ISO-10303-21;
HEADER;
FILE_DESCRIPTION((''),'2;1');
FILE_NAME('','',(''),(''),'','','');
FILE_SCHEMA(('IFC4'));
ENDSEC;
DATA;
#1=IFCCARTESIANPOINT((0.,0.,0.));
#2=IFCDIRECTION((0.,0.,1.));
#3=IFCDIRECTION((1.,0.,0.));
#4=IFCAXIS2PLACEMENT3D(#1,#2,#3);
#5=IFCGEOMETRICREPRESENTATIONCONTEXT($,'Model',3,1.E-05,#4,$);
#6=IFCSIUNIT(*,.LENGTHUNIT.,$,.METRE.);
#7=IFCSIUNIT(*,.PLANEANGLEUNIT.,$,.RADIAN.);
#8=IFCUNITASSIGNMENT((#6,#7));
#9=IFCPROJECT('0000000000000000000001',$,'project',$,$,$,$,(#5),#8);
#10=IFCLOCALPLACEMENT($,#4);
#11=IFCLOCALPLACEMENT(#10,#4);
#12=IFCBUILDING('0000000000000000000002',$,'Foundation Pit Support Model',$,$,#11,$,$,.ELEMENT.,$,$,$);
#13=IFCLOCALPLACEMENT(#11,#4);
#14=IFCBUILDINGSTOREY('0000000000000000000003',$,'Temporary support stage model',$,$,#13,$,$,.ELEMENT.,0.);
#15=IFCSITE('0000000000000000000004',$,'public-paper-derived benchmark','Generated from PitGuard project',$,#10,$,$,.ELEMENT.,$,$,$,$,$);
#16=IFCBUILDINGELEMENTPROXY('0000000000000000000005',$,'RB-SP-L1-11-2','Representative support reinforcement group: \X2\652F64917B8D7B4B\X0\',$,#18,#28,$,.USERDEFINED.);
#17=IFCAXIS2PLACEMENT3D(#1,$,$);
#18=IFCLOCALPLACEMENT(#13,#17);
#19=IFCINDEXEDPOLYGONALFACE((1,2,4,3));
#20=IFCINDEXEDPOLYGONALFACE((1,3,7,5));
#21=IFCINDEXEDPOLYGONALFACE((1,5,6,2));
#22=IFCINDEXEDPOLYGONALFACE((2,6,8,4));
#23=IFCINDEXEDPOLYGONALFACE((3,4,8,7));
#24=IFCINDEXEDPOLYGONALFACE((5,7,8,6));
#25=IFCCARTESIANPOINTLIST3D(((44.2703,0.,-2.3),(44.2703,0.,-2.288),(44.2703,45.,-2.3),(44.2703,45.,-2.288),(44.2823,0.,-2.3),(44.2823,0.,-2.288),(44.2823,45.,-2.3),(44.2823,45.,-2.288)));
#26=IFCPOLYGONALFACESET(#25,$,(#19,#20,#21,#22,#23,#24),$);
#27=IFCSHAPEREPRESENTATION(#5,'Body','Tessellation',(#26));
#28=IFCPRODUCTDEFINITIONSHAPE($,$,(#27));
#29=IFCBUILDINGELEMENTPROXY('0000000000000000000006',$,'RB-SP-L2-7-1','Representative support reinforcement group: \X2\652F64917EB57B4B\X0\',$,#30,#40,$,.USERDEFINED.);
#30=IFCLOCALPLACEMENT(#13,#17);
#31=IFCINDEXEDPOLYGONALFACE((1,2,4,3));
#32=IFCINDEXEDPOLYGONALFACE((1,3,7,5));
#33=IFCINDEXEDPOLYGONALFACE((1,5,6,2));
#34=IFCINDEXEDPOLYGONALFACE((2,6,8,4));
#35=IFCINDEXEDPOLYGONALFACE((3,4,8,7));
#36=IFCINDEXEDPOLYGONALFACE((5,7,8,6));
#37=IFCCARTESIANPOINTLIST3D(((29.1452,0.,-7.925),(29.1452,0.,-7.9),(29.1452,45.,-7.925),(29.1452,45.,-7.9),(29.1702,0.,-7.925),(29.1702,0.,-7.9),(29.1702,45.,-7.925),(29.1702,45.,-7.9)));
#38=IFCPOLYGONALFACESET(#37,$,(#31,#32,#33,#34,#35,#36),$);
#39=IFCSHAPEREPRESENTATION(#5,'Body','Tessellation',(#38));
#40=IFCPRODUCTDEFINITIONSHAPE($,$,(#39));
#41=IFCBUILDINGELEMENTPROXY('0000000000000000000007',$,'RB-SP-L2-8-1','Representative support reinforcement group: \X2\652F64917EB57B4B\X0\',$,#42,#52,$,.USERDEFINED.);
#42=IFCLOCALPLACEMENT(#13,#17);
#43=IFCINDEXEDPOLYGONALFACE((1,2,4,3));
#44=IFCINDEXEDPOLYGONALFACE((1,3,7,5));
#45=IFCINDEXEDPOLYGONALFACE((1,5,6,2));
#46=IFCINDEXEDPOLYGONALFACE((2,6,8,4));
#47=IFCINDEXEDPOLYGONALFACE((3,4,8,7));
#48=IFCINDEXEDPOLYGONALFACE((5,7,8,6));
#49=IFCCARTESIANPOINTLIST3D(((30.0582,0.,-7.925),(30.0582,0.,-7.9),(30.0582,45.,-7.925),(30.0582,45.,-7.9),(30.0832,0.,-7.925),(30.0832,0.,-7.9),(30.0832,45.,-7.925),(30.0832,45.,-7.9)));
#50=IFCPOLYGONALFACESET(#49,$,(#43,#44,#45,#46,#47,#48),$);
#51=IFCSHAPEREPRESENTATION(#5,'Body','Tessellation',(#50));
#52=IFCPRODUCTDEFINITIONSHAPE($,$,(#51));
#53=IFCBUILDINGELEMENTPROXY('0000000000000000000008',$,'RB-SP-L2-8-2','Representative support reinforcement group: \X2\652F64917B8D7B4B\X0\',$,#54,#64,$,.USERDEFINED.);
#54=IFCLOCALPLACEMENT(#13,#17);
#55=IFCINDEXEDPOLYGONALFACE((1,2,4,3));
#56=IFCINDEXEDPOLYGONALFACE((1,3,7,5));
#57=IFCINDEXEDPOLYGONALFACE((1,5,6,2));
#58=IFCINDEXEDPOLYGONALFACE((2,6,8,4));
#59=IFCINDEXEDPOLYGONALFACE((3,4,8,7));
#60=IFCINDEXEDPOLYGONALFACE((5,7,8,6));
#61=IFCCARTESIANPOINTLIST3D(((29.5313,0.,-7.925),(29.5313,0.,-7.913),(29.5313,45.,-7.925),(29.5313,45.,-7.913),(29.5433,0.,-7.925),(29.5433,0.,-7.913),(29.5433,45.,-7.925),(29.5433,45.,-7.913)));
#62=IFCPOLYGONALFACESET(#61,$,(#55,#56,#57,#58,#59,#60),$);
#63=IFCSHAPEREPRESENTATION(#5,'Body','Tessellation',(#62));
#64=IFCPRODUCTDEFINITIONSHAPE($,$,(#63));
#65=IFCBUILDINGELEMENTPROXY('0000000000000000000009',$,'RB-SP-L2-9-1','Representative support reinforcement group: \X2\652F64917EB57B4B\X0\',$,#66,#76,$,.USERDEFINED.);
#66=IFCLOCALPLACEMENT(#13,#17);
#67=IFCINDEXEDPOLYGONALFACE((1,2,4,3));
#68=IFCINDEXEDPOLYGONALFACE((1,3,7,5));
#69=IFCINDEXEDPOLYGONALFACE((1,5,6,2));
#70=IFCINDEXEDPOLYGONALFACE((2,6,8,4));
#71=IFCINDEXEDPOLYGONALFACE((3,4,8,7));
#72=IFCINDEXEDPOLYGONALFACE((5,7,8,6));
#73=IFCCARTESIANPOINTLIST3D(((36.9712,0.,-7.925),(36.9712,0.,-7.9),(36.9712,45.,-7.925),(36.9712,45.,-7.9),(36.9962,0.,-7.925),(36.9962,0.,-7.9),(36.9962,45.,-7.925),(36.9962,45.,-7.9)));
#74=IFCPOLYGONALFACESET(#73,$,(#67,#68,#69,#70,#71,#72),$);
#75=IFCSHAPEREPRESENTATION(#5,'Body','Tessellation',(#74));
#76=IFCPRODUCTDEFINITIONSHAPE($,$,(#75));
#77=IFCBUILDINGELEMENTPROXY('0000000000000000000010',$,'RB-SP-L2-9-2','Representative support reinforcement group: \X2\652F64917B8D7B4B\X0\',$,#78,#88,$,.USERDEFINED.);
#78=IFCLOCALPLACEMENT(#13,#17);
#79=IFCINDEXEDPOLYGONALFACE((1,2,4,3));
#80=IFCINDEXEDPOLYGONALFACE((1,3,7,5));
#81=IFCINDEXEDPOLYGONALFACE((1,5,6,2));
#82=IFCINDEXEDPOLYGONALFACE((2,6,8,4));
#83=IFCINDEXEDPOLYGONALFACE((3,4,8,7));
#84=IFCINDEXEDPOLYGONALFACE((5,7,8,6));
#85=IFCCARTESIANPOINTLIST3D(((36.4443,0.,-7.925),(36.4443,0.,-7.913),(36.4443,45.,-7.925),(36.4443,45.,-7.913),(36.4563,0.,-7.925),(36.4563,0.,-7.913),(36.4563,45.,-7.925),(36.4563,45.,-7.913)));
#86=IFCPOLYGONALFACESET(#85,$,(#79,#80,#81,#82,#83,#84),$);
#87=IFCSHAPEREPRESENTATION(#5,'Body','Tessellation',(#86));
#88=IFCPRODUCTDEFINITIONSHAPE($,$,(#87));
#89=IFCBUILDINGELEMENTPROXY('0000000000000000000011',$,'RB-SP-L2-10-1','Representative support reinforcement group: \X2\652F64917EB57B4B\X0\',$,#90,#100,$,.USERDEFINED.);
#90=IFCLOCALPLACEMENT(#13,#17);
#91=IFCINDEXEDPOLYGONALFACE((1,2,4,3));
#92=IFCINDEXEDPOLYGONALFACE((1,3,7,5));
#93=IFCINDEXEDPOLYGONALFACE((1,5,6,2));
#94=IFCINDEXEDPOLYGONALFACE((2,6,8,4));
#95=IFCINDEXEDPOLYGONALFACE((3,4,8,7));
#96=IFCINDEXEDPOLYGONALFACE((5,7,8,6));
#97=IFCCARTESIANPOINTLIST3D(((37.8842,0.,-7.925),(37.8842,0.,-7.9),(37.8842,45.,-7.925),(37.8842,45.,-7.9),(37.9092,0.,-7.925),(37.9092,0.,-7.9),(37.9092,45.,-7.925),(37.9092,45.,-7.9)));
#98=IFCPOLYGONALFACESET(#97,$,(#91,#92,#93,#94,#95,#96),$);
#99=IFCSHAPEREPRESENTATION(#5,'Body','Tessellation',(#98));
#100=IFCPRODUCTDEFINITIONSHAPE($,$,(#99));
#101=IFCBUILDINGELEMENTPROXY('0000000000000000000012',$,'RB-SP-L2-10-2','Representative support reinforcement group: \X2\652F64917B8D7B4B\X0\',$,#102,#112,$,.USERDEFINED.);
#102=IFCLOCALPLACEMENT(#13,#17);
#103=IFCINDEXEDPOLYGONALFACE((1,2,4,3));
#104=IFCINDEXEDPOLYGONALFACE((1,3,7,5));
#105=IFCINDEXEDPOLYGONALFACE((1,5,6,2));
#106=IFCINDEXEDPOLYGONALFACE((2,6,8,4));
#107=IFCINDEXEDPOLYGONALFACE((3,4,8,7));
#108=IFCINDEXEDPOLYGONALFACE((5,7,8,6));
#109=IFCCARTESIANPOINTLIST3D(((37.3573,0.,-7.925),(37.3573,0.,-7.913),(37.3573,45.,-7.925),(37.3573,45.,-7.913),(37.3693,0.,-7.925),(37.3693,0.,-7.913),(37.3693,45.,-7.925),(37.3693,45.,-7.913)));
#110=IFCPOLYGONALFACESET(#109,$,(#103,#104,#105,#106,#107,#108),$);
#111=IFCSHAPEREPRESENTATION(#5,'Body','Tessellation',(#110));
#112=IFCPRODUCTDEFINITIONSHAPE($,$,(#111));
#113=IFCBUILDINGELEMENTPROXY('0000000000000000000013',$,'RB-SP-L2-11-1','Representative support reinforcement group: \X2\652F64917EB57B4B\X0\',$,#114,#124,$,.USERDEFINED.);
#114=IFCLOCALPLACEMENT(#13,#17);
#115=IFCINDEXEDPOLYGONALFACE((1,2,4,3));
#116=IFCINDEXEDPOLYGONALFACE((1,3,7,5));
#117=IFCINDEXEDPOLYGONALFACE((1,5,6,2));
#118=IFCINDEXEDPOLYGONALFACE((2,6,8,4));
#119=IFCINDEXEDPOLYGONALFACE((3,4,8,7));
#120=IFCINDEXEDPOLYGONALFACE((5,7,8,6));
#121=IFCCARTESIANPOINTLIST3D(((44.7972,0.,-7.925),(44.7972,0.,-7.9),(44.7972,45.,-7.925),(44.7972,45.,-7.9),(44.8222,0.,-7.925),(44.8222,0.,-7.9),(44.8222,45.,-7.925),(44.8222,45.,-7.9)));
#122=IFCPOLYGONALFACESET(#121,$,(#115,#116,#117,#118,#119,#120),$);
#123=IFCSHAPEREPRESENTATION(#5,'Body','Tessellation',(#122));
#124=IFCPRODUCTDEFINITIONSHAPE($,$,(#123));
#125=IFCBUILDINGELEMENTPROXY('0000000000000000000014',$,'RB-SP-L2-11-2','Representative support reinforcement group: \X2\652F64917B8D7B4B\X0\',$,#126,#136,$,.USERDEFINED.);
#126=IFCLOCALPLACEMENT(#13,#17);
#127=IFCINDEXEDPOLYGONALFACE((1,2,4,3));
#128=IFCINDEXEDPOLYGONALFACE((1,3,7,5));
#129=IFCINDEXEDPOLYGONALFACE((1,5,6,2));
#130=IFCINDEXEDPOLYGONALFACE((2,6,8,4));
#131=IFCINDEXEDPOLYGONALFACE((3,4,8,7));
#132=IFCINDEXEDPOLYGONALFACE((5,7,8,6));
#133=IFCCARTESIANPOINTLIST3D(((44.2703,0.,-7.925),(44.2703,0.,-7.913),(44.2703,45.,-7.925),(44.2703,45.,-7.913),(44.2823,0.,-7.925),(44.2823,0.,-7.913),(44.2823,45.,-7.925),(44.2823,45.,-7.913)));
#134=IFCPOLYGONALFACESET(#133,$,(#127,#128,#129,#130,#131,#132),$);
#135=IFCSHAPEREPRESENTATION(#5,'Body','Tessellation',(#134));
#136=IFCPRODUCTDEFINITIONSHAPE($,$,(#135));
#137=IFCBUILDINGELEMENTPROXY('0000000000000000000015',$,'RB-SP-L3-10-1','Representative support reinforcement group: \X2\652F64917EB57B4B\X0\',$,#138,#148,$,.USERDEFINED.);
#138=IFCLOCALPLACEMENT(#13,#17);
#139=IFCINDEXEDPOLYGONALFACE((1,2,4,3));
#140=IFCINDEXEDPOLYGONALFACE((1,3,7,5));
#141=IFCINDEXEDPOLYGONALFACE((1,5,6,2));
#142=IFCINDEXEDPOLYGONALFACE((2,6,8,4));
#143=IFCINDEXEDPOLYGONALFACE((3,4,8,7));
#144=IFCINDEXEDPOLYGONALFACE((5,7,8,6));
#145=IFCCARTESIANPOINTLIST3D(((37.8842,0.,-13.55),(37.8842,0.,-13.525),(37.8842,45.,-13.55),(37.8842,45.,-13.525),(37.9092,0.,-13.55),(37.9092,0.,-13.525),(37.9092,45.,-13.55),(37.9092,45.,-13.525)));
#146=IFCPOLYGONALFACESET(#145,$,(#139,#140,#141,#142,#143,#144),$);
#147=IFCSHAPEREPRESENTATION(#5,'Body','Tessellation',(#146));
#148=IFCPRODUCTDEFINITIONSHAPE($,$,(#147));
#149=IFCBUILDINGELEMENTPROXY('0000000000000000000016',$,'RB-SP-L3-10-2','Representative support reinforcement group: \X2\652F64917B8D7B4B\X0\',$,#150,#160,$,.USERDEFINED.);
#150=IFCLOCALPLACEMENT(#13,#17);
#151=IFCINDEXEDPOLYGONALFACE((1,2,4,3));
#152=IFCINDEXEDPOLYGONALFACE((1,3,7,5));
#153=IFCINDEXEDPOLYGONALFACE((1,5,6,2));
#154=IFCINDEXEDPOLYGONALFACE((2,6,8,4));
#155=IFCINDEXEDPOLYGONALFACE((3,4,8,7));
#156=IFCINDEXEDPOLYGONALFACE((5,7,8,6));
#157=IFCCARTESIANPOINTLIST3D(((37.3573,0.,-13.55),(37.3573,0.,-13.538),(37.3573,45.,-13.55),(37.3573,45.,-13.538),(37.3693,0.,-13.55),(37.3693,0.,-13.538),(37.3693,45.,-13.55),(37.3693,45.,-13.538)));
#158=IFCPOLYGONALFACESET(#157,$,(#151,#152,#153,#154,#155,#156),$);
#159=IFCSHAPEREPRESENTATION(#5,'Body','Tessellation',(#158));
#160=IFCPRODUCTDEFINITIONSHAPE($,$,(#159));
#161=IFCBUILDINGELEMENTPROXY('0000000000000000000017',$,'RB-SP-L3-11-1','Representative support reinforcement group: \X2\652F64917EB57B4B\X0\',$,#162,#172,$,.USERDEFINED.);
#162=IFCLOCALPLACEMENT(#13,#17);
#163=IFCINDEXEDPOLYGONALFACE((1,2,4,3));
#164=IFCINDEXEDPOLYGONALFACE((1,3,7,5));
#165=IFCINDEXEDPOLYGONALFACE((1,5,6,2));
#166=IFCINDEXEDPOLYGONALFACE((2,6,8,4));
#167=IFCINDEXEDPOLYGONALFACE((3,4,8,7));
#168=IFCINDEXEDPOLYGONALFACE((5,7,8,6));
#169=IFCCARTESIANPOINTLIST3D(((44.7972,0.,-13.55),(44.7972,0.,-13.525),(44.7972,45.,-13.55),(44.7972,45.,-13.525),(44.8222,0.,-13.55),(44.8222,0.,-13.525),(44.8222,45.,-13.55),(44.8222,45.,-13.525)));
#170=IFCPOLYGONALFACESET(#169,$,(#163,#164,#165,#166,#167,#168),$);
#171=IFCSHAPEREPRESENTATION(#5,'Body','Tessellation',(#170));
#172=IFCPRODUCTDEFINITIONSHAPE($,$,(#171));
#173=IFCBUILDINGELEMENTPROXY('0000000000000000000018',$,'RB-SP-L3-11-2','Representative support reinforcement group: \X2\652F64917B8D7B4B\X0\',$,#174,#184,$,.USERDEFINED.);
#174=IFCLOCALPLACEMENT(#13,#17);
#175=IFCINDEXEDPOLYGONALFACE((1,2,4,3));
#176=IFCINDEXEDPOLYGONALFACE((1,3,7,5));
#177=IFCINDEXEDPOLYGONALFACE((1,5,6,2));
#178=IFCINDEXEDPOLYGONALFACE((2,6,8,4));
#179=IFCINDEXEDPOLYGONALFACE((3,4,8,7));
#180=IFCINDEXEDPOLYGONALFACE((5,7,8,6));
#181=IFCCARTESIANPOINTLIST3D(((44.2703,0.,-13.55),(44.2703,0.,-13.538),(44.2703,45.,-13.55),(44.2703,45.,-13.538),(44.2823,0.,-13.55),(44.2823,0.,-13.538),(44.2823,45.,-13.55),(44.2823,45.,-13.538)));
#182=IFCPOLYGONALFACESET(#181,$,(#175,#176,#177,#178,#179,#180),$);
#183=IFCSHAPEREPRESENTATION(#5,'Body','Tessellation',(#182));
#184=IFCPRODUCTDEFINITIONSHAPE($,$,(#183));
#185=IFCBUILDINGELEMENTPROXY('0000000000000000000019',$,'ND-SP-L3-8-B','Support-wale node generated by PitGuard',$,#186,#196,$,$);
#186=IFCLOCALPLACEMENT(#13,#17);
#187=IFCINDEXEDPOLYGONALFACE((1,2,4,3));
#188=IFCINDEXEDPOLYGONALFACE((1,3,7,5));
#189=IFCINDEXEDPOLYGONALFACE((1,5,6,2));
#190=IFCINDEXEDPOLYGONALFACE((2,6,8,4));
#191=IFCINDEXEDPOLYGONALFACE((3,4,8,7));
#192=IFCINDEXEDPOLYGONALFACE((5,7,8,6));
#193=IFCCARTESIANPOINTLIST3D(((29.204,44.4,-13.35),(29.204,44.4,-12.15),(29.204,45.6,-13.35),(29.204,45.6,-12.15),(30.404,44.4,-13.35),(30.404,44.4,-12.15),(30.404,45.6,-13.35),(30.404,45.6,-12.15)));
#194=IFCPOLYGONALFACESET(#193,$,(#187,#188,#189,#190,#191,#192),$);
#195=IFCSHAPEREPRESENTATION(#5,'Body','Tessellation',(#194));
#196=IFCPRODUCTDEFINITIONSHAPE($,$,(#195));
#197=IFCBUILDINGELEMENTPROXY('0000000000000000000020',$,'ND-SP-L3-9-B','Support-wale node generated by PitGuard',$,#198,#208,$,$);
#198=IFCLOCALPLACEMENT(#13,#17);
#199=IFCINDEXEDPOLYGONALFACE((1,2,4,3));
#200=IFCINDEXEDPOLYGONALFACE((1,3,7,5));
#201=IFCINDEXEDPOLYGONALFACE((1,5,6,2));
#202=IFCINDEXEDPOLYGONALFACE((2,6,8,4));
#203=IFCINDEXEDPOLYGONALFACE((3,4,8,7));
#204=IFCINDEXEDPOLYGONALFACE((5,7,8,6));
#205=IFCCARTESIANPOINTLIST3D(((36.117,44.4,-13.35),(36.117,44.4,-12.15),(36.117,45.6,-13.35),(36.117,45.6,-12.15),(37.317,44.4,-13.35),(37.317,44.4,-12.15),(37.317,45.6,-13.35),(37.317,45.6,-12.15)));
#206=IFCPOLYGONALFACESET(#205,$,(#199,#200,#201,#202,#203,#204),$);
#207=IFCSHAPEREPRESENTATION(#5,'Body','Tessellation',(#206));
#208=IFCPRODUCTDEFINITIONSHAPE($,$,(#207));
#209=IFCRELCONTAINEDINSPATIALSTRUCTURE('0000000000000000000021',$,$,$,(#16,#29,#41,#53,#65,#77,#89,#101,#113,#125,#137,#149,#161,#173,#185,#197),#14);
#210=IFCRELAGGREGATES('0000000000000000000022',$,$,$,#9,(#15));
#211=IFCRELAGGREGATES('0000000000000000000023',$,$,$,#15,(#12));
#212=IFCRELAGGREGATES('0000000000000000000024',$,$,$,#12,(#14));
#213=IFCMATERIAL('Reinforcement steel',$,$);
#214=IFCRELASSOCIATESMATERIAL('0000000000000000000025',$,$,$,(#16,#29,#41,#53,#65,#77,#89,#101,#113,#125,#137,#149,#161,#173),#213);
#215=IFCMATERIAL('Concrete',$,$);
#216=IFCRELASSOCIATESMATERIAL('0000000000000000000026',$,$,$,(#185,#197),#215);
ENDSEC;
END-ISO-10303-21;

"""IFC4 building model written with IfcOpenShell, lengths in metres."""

from ifc_helpers import new_model, si_unit, frame, origin_with_axes, origin_2d, place, context, project, spatial, rectangle, extrude, material, element, save


model = new_model("IFC4")

# Units and contexts
model_context = context("Model", 3, precision=1e-05, world=origin_with_axes())
ifc_project = project(units=[si_unit("LENGTHUNIT", "METRE"), si_unit("PLANEANGLEUNIT", "RADIAN")], contexts=[model_context])

# Site, building, storey
site_placement = place(None, origin_with_axes())
site = spatial("IfcSite", under=ifc_project, at=site_placement, Name="public-paper-derived benchmark", Description="Generated from PitGuard project", CompositionType="ELEMENT")
building_placement = place(site_placement, origin_with_axes())
building = spatial("IfcBuilding", under=site, at=building_placement, Name="Foundation Pit Support Model", CompositionType="ELEMENT")
storey_placement = place(building_placement, origin_with_axes())
storey = spatial("IfcBuildingStorey", under=building, at=storey_placement, Name="Temporary support stage model", CompositionType="ELEMENT", Elevation=0.0)

# Shared definitions
ifc_material_1 = material(Name="Concrete")

# Building element proxies
ifc_material_2 = material(Name="Reinforcement steel")
proxy_1_placement = place(storey_placement, frame((44.2763, 22.5, -2.3), z_axis=(0.0, 0.0, 1.0), x_axis=(0.0, 1.0, 0.0)))
element("IfcBuildingElementProxy", 1, at=proxy_1_placement, inside=storey, material=ifc_material_2, Name="RB-SP-L1-11-2", Description="Representative support reinforcement group: 支撑箍筋", PredefinedType="USERDEFINED", context=model_context, shape_type="SweptSolid", body=[
    extrude(rectangle(XDim=45.0, YDim=0.012, at=origin_2d()), origin_with_axes(), (0.0, 0.0, 1.0), 0.012),
])
for number, where, z_axis, x_axis, name in (
    (2, (29.1577, 22.5, -7.925), (0.0, 0.0, 1.0), (0.0, 1.0, 0.0), "RB-SP-L2-7-1"),
    (3, (30.0707, 22.5, -7.925), (0.0, 0.0, 1.0), (0.0, 1.0, 0.0), "RB-SP-L2-8-1"),
):
    element("IfcBuildingElementProxy", number, at=place(storey_placement, frame(where, z_axis=z_axis, x_axis=x_axis)), inside=storey, material=ifc_material_2, Name=name, Description="Representative support reinforcement group: 支撑纵筋", PredefinedType="USERDEFINED", context=model_context, shape_type="SweptSolid", body=[
        extrude(rectangle(XDim=45.0, YDim=0.025, at=origin_2d()), origin_with_axes(), (0.0, 0.0, 1.0), 0.025),
    ])
proxy_2_placement = place(storey_placement, frame((29.5373, 22.5, -7.925), z_axis=(0.0, 0.0, 1.0), x_axis=(0.0, 1.0, 0.0)))
element("IfcBuildingElementProxy", 4, at=proxy_2_placement, inside=storey, material=ifc_material_2, Name="RB-SP-L2-8-2", Description="Representative support reinforcement group: 支撑箍筋", PredefinedType="USERDEFINED", context=model_context, shape_type="SweptSolid", body=[
    extrude(rectangle(XDim=45.0, YDim=0.012, at=origin_2d()), origin_with_axes(), (0.0, 0.0, 1.0), 0.012),
])
proxy_3_placement = place(storey_placement, frame((36.9837, 22.5, -7.925), z_axis=(0.0, 0.0, 1.0), x_axis=(0.0, 1.0, 0.0)))
element("IfcBuildingElementProxy", 5, at=proxy_3_placement, inside=storey, material=ifc_material_2, Name="RB-SP-L2-9-1", Description="Representative support reinforcement group: 支撑纵筋", PredefinedType="USERDEFINED", context=model_context, shape_type="SweptSolid", body=[
    extrude(rectangle(XDim=45.0, YDim=0.025, at=origin_2d()), origin_with_axes(), (0.0, 0.0, 1.0), 0.025),
])
proxy_4_placement = place(storey_placement, frame((36.4503, 22.5, -7.925), z_axis=(0.0, 0.0, 1.0), x_axis=(0.0, 1.0, 0.0)))
element("IfcBuildingElementProxy", 6, at=proxy_4_placement, inside=storey, material=ifc_material_2, Name="RB-SP-L2-9-2", Description="Representative support reinforcement group: 支撑箍筋", PredefinedType="USERDEFINED", context=model_context, shape_type="SweptSolid", body=[
    extrude(rectangle(XDim=45.0, YDim=0.012, at=origin_2d()), origin_with_axes(), (0.0, 0.0, 1.0), 0.012),
])
proxy_5_placement = place(storey_placement, frame((37.8967, 22.5, -7.925), z_axis=(0.0, 0.0, 1.0), x_axis=(0.0, 1.0, 0.0)))
element("IfcBuildingElementProxy", 7, at=proxy_5_placement, inside=storey, material=ifc_material_2, Name="RB-SP-L2-10-1", Description="Representative support reinforcement group: 支撑纵筋", PredefinedType="USERDEFINED", context=model_context, shape_type="SweptSolid", body=[
    extrude(rectangle(XDim=45.0, YDim=0.025, at=origin_2d()), origin_with_axes(), (0.0, 0.0, 1.0), 0.025),
])
proxy_6_placement = place(storey_placement, frame((37.3633, 22.5, -7.925), z_axis=(0.0, 0.0, 1.0), x_axis=(0.0, 1.0, 0.0)))
element("IfcBuildingElementProxy", 8, at=proxy_6_placement, inside=storey, material=ifc_material_2, Name="RB-SP-L2-10-2", Description="Representative support reinforcement group: 支撑箍筋", PredefinedType="USERDEFINED", context=model_context, shape_type="SweptSolid", body=[
    extrude(rectangle(XDim=45.0, YDim=0.012, at=origin_2d()), origin_with_axes(), (0.0, 0.0, 1.0), 0.012),
])
proxy_7_placement = place(storey_placement, frame((44.8097, 22.5, -7.925), z_axis=(0.0, 0.0, 1.0), x_axis=(0.0, 1.0, 0.0)))
element("IfcBuildingElementProxy", 9, at=proxy_7_placement, inside=storey, material=ifc_material_2, Name="RB-SP-L2-11-1", Description="Representative support reinforcement group: 支撑纵筋", PredefinedType="USERDEFINED", context=model_context, shape_type="SweptSolid", body=[
    extrude(rectangle(XDim=45.0, YDim=0.025, at=origin_2d()), origin_with_axes(), (0.0, 0.0, 1.0), 0.025),
])
proxy_8_placement = place(storey_placement, frame((44.2763, 22.5, -7.925), z_axis=(0.0, 0.0, 1.0), x_axis=(0.0, 1.0, 0.0)))
element("IfcBuildingElementProxy", 10, at=proxy_8_placement, inside=storey, material=ifc_material_2, Name="RB-SP-L2-11-2", Description="Representative support reinforcement group: 支撑箍筋", PredefinedType="USERDEFINED", context=model_context, shape_type="SweptSolid", body=[
    extrude(rectangle(XDim=45.0, YDim=0.012, at=origin_2d()), origin_with_axes(), (0.0, 0.0, 1.0), 0.012),
])
proxy_9_placement = place(storey_placement, frame((37.8967, 22.5, -13.55), z_axis=(0.0, 0.0, 1.0), x_axis=(0.0, 1.0, 0.0)))
element("IfcBuildingElementProxy", 11, at=proxy_9_placement, inside=storey, material=ifc_material_2, Name="RB-SP-L3-10-1", Description="Representative support reinforcement group: 支撑纵筋", PredefinedType="USERDEFINED", context=model_context, shape_type="SweptSolid", body=[
    extrude(rectangle(XDim=45.0, YDim=0.025, at=origin_2d()), origin_with_axes(), (0.0, 0.0, 1.0), 0.025),
])
proxy_10_placement = place(storey_placement, frame((37.3633, 22.5, -13.55), z_axis=(0.0, 0.0, 1.0), x_axis=(0.0, 1.0, 0.0)))
element("IfcBuildingElementProxy", 12, at=proxy_10_placement, inside=storey, material=ifc_material_2, Name="RB-SP-L3-10-2", Description="Representative support reinforcement group: 支撑箍筋", PredefinedType="USERDEFINED", context=model_context, shape_type="SweptSolid", body=[
    extrude(rectangle(XDim=45.0, YDim=0.012, at=origin_2d()), origin_with_axes(), (0.0, 0.0, 1.0), 0.012),
])
proxy_11_placement = place(storey_placement, frame((44.8097, 22.5, -13.55), z_axis=(0.0, 0.0, 1.0), x_axis=(0.0, 1.0, 0.0)))
element("IfcBuildingElementProxy", 13, at=proxy_11_placement, inside=storey, material=ifc_material_2, Name="RB-SP-L3-11-1", Description="Representative support reinforcement group: 支撑纵筋", PredefinedType="USERDEFINED", context=model_context, shape_type="SweptSolid", body=[
    extrude(rectangle(XDim=45.0, YDim=0.025, at=origin_2d()), origin_with_axes(), (0.0, 0.0, 1.0), 0.025),
])
proxy_12_placement = place(storey_placement, frame((44.2763, 22.5, -13.55), z_axis=(0.0, 0.0, 1.0), x_axis=(0.0, 1.0, 0.0)))
element("IfcBuildingElementProxy", 14, at=proxy_12_placement, inside=storey, material=ifc_material_2, Name="RB-SP-L3-11-2", Description="Representative support reinforcement group: 支撑箍筋", PredefinedType="USERDEFINED", context=model_context, shape_type="SweptSolid", body=[
    extrude(rectangle(XDim=45.0, YDim=0.012, at=origin_2d()), origin_with_axes(), (0.0, 0.0, 1.0), 0.012),
])
for number, where, z_axis, x_axis, name in (
    (15, (29.804, 45.0, -13.35), (0.0, 0.0, 1.0), (1.0, 0.0, 0.0), "ND-SP-L3-8-B"),
    (16, (36.717, 45.0, -13.35), (0.0, 0.0, 1.0), (1.0, 0.0, 0.0), "ND-SP-L3-9-B"),
):
    element("IfcBuildingElementProxy", number, at=place(storey_placement, frame(where, z_axis=z_axis, x_axis=x_axis)), inside=storey, material=ifc_material_1, Name=name, Description="Support-wale node generated by PitGuard", context=model_context, shape_type="SweptSolid", body=[
        extrude(rectangle(XDim=1.2, YDim=1.2, at=origin_2d()), origin_with_axes(), (0.0, 0.0, 1.0), 1.2),
    ])

save(model, "model.ifc")
